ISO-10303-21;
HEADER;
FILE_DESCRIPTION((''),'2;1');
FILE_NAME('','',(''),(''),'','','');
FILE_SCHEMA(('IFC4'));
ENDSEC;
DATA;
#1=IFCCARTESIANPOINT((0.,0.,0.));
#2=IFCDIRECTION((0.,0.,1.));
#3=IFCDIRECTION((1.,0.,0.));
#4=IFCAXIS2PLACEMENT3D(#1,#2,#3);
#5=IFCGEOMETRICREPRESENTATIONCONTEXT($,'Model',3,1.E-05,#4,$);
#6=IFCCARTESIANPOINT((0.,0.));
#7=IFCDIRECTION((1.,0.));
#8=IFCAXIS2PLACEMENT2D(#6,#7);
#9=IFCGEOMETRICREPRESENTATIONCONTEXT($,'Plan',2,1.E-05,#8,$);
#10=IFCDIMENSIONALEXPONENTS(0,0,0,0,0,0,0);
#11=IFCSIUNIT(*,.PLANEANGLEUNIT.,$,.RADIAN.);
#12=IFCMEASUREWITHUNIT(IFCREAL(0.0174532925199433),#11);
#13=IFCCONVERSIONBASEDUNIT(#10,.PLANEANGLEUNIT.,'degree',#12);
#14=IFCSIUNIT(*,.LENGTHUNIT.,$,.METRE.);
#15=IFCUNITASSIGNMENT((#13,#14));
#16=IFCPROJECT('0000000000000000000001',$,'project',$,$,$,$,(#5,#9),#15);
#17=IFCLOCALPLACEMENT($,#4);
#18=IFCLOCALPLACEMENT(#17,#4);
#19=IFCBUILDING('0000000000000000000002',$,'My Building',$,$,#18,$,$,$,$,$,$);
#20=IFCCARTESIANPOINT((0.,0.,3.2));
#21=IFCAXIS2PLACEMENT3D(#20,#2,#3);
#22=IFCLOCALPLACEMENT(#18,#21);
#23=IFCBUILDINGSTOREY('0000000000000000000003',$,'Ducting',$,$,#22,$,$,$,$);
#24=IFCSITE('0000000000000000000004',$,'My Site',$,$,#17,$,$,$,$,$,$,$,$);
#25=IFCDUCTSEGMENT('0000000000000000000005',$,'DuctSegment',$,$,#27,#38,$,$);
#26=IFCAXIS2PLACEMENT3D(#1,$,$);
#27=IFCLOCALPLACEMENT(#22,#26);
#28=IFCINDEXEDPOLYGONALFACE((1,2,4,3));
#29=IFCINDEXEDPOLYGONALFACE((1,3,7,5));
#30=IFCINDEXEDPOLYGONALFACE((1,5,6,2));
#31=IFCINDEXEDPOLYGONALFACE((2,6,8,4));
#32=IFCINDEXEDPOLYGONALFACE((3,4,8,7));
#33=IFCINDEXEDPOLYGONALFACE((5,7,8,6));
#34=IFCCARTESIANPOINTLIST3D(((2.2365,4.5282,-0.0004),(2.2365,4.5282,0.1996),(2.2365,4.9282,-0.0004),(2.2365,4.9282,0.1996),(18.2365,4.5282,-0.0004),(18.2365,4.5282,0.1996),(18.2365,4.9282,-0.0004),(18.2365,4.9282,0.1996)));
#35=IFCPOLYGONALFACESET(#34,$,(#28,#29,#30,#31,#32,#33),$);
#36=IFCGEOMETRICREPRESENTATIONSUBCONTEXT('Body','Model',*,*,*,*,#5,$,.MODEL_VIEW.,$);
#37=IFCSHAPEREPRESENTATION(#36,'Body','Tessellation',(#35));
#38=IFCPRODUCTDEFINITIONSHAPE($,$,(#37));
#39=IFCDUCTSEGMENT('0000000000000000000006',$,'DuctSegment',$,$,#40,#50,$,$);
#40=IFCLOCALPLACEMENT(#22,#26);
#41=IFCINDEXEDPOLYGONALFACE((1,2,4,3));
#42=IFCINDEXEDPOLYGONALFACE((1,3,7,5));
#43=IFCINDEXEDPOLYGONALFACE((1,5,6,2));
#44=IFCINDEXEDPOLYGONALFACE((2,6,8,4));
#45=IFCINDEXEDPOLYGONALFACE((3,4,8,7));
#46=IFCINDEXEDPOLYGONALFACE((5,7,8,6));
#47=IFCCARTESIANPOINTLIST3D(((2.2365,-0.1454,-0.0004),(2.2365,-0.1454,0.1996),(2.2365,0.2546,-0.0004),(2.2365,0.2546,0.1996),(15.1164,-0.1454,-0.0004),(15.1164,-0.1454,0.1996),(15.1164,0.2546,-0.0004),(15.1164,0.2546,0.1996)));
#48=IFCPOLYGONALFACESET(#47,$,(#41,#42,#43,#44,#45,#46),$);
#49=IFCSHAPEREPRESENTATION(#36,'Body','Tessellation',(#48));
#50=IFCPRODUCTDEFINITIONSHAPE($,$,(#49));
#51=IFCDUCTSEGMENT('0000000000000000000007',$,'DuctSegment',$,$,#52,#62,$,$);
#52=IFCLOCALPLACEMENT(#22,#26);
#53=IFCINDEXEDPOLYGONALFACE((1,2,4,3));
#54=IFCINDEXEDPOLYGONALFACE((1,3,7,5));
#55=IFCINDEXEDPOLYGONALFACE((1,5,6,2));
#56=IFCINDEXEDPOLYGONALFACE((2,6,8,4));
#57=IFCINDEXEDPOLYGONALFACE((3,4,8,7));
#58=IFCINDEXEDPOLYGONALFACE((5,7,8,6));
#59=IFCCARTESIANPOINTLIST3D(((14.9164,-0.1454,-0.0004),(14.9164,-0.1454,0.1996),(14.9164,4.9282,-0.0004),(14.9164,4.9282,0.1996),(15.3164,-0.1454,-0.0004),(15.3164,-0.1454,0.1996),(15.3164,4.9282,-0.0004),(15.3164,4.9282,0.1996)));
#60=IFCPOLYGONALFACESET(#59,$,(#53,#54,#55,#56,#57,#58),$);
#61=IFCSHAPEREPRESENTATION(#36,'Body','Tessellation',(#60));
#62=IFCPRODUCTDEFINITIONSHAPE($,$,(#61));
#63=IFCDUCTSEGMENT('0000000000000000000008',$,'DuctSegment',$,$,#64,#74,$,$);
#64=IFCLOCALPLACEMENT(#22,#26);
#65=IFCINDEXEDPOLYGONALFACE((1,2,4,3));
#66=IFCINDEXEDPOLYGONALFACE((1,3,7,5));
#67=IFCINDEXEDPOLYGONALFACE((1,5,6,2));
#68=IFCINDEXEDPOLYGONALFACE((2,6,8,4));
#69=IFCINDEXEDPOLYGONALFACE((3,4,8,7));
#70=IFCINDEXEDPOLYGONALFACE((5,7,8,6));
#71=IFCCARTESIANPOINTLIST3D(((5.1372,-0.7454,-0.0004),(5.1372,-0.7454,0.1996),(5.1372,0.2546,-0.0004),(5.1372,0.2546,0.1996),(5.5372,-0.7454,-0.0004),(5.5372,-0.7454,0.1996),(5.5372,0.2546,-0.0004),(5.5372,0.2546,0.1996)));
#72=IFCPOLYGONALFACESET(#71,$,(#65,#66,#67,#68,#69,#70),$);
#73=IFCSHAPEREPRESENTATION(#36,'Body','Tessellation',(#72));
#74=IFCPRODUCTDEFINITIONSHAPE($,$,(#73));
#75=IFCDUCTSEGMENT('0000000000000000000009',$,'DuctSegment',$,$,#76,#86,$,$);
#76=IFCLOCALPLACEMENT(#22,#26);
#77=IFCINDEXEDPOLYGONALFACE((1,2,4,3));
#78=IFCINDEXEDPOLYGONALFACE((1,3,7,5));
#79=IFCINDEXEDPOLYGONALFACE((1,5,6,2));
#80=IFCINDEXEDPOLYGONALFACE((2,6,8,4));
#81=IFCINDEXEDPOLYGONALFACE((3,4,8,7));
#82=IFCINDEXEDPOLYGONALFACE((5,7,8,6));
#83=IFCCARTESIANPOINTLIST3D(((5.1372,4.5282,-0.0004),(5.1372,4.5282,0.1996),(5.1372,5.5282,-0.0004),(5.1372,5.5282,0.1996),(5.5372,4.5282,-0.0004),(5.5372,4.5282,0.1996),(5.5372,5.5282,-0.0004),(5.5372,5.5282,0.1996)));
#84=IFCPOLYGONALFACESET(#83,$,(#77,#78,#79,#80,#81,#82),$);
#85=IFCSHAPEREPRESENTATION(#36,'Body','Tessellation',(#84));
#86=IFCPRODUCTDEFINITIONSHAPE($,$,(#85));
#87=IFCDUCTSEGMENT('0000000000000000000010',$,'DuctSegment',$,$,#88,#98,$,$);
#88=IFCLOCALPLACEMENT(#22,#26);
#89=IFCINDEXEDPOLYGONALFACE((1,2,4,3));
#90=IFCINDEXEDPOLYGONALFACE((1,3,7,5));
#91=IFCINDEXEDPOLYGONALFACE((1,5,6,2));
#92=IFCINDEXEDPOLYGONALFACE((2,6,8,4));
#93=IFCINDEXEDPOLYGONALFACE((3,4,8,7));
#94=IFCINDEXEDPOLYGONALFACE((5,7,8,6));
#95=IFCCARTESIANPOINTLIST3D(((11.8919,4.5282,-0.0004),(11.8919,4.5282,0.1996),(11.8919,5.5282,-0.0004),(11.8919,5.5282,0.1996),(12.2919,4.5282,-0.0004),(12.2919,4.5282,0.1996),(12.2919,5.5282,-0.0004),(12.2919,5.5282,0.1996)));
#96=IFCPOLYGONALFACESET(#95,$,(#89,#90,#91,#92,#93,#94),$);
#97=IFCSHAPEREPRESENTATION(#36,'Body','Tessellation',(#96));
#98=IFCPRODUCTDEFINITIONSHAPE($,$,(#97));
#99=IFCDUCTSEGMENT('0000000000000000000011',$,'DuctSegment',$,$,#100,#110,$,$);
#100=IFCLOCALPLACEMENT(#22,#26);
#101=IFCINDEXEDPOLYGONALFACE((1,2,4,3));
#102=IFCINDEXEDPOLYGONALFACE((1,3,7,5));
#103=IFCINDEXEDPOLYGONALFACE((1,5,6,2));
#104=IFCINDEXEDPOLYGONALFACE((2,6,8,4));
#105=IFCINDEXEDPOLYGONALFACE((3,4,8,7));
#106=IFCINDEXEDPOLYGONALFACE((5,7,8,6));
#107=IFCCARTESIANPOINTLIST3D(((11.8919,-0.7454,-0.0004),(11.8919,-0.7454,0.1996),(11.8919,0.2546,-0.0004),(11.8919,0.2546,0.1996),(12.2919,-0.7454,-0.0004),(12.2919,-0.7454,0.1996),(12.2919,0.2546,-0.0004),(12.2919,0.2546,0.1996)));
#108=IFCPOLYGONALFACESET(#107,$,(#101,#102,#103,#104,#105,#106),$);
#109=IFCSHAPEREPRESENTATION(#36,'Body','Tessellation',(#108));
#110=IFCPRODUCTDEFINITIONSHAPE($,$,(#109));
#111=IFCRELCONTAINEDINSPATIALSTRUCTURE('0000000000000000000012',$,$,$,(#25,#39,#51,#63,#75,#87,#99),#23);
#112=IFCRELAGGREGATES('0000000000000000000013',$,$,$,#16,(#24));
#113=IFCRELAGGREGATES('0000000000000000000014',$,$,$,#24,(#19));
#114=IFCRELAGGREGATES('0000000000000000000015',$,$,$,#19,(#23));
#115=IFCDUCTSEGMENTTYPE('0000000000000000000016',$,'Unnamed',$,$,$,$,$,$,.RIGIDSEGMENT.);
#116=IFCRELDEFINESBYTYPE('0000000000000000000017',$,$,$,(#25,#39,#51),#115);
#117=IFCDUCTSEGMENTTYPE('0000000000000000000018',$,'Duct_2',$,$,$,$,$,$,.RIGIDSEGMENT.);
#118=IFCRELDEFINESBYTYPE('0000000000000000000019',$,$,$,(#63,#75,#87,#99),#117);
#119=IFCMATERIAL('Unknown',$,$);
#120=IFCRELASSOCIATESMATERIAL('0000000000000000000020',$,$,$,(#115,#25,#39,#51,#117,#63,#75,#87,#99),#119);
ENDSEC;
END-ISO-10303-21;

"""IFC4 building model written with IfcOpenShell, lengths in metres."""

from ifc_helpers import new_model, entity, si_unit, converted_unit, frame, origin_with_axes, origin_2d_with_axis, place, context, subcontext, project, spatial, rectangle, extrude, material, material_profile, profile_set, profile_usage, type_object, element, save


model = new_model("IFC4")

# Units and contexts
model_context = context("Model", 3, precision=1e-05, world=origin_with_axes())
plan_context = context("Plan", 2, precision=1e-05, world=origin_2d_with_axis())
body_context = subcontext(model_context, "Body", "Model", "MODEL_VIEW")
ifc_project = project(units=[converted_unit("PLANEANGLEUNIT", "degree", entity("IfcReal", 0.0174532925199433), si_unit("PLANEANGLEUNIT", "RADIAN"), dimensions=[0, 0, 0, 0, 0, 0, 0]), si_unit("LENGTHUNIT", "METRE")], contexts=[model_context, plan_context])

# Site, building, storey
site_placement = place(None, origin_with_axes())
site = spatial("IfcSite", under=ifc_project, at=site_placement, Name="My Site")
building_placement = place(site_placement, origin_with_axes())
building = spatial("IfcBuilding", under=site, at=building_placement, Name="My Building")
storey_placement = place(building_placement, frame((0.0, 0.0, 3.2), z_axis=(0.0, 0.0, 1.0), x_axis=(1.0, 0.0, 0.0)))
storey = spatial("IfcBuildingStorey", under=building, at=storey_placement, Name="Ducting")

# Duct segments
ifc_material = material(Name="Unknown")
ifc_material_profile_1 = material_profile(ifc_material, rectangle(XDim=0.4, YDim=0.2))
ifc_profile_set_1 = profile_set([ifc_material_profile_1])
ifc_profile_usage_1 = profile_usage(ifc_profile_set_1, cardinal=5)
duct_segment_type_1 = type_object("IfcDuctSegmentType", Name="Unnamed", PredefinedType="RIGIDSEGMENT", material=ifc_profile_set_1)
duct_segment_1_placement = place(storey_placement, frame((18.2365, 4.7282, 0.0996), z_axis=(-1.0, 0.0, 0.0), x_axis=(0.0, -1.0, 0.0)))
element("IfcDuctSegment", 1, at=duct_segment_1_placement, inside=storey, type_object=duct_segment_type_1, material=ifc_profile_usage_1, Name="DuctSegment", context=body_context, shape_type="SweptSolid", body=[
    extrude(rectangle(XDim=0.4, YDim=0.2), origin_with_axes(), (0.0, 0.0, 1.0), 16.0),
])
ifc_profile_usage_2 = profile_usage(ifc_profile_set_1, cardinal=5)
duct_segment_2_placement = place(storey_placement, frame((15.1164, 0.0546, 0.0996), z_axis=(-1.0, 0.0, 0.0), x_axis=(0.0, -1.0, 0.0)))
element("IfcDuctSegment", 2, at=duct_segment_2_placement, inside=storey, type_object=duct_segment_type_1, material=ifc_profile_usage_2, Name="DuctSegment", context=body_context, shape_type="SweptSolid", body=[
    extrude(rectangle(XDim=0.4, YDim=0.2), origin_with_axes(), (0.0, 0.0, 1.0), 12.8799),
])
ifc_profile_usage_3 = profile_usage(ifc_profile_set_1, cardinal=5)
duct_segment_3_placement = place(storey_placement, frame((15.1164, -0.1454, 0.0996), z_axis=(0.0, 1.0, 0.0), x_axis=(-1.0, 0.0, 0.0)))
element("IfcDuctSegment", 3, at=duct_segment_3_placement, inside=storey, type_object=duct_segment_type_1, material=ifc_profile_usage_3, Name="DuctSegment", context=body_context, shape_type="SweptSolid", body=[
    extrude(rectangle(XDim=0.4, YDim=0.2), origin_with_axes(), (0.0, 0.0, 1.0), 5.0736),
])
ifc_material_profile_2 = material_profile(ifc_material, rectangle(XDim=0.4, YDim=0.2))
ifc_profile_set_2 = profile_set([ifc_material_profile_2])
ifc_profile_usage_4 = profile_usage(ifc_profile_set_2, cardinal=5)
duct_segment_type_2 = type_object("IfcDuctSegmentType", Name="Duct_2", PredefinedType="RIGIDSEGMENT", material=ifc_profile_set_2)
duct_segment_4_placement = place(storey_placement, frame((5.3372, 0.2546, 0.0996), z_axis=(0.0, -1.0, -0.000016), x_axis=(1.0, 0.0, 0.0)))
element("IfcDuctSegment", 4, at=duct_segment_4_placement, inside=storey, type_object=duct_segment_type_2, material=ifc_profile_usage_4, Name="DuctSegment", context=body_context, shape_type="SweptSolid", body=[
    extrude(rectangle(XDim=0.4, YDim=0.2), origin_with_axes(), (0.0, 0.0, 1.0), 1.0),
])
ifc_profile_usage_5 = profile_usage(ifc_profile_set_2, cardinal=5)
duct_segment_5_placement = place(storey_placement, frame((5.3372, 5.5282, 0.0996), z_axis=(0.0, -1.0, -0.000016), x_axis=(1.0, 0.0, 0.0)))
element("IfcDuctSegment", 5, at=duct_segment_5_placement, inside=storey, type_object=duct_segment_type_2, material=ifc_profile_usage_5, Name="DuctSegment", context=body_context, shape_type="SweptSolid", body=[
    extrude(rectangle(XDim=0.4, YDim=0.2), origin_with_axes(), (0.0, 0.0, 1.0), 1.0),
])
ifc_profile_usage_6 = profile_usage(ifc_profile_set_2, cardinal=5)
duct_segment_6_placement = place(storey_placement, frame((12.0919, 5.5282, 0.0996), z_axis=(0.0, -1.0, -0.000016), x_axis=(1.0, 0.0, 0.0)))
element("IfcDuctSegment", 6, at=duct_segment_6_placement, inside=storey, type_object=duct_segment_type_2, material=ifc_profile_usage_6, Name="DuctSegment", context=body_context, shape_type="SweptSolid", body=[
    extrude(rectangle(XDim=0.4, YDim=0.2), origin_with_axes(), (0.0, 0.0, 1.0), 1.0),
])
ifc_profile_usage_7 = profile_usage(ifc_profile_set_2, cardinal=5)
duct_segment_7_placement = place(storey_placement, frame((12.0919, 0.2546, 0.0996), z_axis=(0.0, -1.0, -0.000016), x_axis=(1.0, 0.0, 0.0)))
element("IfcDuctSegment", 7, at=duct_segment_7_placement, inside=storey, type_object=duct_segment_type_2, material=ifc_profile_usage_7, Name="DuctSegment", context=body_context, shape_type="SweptSolid", body=[
    extrude(rectangle(XDim=0.4, YDim=0.2), origin_with_axes(), (0.0, 0.0, 1.0), 1.0),
])

save(model, "model.ifc")
